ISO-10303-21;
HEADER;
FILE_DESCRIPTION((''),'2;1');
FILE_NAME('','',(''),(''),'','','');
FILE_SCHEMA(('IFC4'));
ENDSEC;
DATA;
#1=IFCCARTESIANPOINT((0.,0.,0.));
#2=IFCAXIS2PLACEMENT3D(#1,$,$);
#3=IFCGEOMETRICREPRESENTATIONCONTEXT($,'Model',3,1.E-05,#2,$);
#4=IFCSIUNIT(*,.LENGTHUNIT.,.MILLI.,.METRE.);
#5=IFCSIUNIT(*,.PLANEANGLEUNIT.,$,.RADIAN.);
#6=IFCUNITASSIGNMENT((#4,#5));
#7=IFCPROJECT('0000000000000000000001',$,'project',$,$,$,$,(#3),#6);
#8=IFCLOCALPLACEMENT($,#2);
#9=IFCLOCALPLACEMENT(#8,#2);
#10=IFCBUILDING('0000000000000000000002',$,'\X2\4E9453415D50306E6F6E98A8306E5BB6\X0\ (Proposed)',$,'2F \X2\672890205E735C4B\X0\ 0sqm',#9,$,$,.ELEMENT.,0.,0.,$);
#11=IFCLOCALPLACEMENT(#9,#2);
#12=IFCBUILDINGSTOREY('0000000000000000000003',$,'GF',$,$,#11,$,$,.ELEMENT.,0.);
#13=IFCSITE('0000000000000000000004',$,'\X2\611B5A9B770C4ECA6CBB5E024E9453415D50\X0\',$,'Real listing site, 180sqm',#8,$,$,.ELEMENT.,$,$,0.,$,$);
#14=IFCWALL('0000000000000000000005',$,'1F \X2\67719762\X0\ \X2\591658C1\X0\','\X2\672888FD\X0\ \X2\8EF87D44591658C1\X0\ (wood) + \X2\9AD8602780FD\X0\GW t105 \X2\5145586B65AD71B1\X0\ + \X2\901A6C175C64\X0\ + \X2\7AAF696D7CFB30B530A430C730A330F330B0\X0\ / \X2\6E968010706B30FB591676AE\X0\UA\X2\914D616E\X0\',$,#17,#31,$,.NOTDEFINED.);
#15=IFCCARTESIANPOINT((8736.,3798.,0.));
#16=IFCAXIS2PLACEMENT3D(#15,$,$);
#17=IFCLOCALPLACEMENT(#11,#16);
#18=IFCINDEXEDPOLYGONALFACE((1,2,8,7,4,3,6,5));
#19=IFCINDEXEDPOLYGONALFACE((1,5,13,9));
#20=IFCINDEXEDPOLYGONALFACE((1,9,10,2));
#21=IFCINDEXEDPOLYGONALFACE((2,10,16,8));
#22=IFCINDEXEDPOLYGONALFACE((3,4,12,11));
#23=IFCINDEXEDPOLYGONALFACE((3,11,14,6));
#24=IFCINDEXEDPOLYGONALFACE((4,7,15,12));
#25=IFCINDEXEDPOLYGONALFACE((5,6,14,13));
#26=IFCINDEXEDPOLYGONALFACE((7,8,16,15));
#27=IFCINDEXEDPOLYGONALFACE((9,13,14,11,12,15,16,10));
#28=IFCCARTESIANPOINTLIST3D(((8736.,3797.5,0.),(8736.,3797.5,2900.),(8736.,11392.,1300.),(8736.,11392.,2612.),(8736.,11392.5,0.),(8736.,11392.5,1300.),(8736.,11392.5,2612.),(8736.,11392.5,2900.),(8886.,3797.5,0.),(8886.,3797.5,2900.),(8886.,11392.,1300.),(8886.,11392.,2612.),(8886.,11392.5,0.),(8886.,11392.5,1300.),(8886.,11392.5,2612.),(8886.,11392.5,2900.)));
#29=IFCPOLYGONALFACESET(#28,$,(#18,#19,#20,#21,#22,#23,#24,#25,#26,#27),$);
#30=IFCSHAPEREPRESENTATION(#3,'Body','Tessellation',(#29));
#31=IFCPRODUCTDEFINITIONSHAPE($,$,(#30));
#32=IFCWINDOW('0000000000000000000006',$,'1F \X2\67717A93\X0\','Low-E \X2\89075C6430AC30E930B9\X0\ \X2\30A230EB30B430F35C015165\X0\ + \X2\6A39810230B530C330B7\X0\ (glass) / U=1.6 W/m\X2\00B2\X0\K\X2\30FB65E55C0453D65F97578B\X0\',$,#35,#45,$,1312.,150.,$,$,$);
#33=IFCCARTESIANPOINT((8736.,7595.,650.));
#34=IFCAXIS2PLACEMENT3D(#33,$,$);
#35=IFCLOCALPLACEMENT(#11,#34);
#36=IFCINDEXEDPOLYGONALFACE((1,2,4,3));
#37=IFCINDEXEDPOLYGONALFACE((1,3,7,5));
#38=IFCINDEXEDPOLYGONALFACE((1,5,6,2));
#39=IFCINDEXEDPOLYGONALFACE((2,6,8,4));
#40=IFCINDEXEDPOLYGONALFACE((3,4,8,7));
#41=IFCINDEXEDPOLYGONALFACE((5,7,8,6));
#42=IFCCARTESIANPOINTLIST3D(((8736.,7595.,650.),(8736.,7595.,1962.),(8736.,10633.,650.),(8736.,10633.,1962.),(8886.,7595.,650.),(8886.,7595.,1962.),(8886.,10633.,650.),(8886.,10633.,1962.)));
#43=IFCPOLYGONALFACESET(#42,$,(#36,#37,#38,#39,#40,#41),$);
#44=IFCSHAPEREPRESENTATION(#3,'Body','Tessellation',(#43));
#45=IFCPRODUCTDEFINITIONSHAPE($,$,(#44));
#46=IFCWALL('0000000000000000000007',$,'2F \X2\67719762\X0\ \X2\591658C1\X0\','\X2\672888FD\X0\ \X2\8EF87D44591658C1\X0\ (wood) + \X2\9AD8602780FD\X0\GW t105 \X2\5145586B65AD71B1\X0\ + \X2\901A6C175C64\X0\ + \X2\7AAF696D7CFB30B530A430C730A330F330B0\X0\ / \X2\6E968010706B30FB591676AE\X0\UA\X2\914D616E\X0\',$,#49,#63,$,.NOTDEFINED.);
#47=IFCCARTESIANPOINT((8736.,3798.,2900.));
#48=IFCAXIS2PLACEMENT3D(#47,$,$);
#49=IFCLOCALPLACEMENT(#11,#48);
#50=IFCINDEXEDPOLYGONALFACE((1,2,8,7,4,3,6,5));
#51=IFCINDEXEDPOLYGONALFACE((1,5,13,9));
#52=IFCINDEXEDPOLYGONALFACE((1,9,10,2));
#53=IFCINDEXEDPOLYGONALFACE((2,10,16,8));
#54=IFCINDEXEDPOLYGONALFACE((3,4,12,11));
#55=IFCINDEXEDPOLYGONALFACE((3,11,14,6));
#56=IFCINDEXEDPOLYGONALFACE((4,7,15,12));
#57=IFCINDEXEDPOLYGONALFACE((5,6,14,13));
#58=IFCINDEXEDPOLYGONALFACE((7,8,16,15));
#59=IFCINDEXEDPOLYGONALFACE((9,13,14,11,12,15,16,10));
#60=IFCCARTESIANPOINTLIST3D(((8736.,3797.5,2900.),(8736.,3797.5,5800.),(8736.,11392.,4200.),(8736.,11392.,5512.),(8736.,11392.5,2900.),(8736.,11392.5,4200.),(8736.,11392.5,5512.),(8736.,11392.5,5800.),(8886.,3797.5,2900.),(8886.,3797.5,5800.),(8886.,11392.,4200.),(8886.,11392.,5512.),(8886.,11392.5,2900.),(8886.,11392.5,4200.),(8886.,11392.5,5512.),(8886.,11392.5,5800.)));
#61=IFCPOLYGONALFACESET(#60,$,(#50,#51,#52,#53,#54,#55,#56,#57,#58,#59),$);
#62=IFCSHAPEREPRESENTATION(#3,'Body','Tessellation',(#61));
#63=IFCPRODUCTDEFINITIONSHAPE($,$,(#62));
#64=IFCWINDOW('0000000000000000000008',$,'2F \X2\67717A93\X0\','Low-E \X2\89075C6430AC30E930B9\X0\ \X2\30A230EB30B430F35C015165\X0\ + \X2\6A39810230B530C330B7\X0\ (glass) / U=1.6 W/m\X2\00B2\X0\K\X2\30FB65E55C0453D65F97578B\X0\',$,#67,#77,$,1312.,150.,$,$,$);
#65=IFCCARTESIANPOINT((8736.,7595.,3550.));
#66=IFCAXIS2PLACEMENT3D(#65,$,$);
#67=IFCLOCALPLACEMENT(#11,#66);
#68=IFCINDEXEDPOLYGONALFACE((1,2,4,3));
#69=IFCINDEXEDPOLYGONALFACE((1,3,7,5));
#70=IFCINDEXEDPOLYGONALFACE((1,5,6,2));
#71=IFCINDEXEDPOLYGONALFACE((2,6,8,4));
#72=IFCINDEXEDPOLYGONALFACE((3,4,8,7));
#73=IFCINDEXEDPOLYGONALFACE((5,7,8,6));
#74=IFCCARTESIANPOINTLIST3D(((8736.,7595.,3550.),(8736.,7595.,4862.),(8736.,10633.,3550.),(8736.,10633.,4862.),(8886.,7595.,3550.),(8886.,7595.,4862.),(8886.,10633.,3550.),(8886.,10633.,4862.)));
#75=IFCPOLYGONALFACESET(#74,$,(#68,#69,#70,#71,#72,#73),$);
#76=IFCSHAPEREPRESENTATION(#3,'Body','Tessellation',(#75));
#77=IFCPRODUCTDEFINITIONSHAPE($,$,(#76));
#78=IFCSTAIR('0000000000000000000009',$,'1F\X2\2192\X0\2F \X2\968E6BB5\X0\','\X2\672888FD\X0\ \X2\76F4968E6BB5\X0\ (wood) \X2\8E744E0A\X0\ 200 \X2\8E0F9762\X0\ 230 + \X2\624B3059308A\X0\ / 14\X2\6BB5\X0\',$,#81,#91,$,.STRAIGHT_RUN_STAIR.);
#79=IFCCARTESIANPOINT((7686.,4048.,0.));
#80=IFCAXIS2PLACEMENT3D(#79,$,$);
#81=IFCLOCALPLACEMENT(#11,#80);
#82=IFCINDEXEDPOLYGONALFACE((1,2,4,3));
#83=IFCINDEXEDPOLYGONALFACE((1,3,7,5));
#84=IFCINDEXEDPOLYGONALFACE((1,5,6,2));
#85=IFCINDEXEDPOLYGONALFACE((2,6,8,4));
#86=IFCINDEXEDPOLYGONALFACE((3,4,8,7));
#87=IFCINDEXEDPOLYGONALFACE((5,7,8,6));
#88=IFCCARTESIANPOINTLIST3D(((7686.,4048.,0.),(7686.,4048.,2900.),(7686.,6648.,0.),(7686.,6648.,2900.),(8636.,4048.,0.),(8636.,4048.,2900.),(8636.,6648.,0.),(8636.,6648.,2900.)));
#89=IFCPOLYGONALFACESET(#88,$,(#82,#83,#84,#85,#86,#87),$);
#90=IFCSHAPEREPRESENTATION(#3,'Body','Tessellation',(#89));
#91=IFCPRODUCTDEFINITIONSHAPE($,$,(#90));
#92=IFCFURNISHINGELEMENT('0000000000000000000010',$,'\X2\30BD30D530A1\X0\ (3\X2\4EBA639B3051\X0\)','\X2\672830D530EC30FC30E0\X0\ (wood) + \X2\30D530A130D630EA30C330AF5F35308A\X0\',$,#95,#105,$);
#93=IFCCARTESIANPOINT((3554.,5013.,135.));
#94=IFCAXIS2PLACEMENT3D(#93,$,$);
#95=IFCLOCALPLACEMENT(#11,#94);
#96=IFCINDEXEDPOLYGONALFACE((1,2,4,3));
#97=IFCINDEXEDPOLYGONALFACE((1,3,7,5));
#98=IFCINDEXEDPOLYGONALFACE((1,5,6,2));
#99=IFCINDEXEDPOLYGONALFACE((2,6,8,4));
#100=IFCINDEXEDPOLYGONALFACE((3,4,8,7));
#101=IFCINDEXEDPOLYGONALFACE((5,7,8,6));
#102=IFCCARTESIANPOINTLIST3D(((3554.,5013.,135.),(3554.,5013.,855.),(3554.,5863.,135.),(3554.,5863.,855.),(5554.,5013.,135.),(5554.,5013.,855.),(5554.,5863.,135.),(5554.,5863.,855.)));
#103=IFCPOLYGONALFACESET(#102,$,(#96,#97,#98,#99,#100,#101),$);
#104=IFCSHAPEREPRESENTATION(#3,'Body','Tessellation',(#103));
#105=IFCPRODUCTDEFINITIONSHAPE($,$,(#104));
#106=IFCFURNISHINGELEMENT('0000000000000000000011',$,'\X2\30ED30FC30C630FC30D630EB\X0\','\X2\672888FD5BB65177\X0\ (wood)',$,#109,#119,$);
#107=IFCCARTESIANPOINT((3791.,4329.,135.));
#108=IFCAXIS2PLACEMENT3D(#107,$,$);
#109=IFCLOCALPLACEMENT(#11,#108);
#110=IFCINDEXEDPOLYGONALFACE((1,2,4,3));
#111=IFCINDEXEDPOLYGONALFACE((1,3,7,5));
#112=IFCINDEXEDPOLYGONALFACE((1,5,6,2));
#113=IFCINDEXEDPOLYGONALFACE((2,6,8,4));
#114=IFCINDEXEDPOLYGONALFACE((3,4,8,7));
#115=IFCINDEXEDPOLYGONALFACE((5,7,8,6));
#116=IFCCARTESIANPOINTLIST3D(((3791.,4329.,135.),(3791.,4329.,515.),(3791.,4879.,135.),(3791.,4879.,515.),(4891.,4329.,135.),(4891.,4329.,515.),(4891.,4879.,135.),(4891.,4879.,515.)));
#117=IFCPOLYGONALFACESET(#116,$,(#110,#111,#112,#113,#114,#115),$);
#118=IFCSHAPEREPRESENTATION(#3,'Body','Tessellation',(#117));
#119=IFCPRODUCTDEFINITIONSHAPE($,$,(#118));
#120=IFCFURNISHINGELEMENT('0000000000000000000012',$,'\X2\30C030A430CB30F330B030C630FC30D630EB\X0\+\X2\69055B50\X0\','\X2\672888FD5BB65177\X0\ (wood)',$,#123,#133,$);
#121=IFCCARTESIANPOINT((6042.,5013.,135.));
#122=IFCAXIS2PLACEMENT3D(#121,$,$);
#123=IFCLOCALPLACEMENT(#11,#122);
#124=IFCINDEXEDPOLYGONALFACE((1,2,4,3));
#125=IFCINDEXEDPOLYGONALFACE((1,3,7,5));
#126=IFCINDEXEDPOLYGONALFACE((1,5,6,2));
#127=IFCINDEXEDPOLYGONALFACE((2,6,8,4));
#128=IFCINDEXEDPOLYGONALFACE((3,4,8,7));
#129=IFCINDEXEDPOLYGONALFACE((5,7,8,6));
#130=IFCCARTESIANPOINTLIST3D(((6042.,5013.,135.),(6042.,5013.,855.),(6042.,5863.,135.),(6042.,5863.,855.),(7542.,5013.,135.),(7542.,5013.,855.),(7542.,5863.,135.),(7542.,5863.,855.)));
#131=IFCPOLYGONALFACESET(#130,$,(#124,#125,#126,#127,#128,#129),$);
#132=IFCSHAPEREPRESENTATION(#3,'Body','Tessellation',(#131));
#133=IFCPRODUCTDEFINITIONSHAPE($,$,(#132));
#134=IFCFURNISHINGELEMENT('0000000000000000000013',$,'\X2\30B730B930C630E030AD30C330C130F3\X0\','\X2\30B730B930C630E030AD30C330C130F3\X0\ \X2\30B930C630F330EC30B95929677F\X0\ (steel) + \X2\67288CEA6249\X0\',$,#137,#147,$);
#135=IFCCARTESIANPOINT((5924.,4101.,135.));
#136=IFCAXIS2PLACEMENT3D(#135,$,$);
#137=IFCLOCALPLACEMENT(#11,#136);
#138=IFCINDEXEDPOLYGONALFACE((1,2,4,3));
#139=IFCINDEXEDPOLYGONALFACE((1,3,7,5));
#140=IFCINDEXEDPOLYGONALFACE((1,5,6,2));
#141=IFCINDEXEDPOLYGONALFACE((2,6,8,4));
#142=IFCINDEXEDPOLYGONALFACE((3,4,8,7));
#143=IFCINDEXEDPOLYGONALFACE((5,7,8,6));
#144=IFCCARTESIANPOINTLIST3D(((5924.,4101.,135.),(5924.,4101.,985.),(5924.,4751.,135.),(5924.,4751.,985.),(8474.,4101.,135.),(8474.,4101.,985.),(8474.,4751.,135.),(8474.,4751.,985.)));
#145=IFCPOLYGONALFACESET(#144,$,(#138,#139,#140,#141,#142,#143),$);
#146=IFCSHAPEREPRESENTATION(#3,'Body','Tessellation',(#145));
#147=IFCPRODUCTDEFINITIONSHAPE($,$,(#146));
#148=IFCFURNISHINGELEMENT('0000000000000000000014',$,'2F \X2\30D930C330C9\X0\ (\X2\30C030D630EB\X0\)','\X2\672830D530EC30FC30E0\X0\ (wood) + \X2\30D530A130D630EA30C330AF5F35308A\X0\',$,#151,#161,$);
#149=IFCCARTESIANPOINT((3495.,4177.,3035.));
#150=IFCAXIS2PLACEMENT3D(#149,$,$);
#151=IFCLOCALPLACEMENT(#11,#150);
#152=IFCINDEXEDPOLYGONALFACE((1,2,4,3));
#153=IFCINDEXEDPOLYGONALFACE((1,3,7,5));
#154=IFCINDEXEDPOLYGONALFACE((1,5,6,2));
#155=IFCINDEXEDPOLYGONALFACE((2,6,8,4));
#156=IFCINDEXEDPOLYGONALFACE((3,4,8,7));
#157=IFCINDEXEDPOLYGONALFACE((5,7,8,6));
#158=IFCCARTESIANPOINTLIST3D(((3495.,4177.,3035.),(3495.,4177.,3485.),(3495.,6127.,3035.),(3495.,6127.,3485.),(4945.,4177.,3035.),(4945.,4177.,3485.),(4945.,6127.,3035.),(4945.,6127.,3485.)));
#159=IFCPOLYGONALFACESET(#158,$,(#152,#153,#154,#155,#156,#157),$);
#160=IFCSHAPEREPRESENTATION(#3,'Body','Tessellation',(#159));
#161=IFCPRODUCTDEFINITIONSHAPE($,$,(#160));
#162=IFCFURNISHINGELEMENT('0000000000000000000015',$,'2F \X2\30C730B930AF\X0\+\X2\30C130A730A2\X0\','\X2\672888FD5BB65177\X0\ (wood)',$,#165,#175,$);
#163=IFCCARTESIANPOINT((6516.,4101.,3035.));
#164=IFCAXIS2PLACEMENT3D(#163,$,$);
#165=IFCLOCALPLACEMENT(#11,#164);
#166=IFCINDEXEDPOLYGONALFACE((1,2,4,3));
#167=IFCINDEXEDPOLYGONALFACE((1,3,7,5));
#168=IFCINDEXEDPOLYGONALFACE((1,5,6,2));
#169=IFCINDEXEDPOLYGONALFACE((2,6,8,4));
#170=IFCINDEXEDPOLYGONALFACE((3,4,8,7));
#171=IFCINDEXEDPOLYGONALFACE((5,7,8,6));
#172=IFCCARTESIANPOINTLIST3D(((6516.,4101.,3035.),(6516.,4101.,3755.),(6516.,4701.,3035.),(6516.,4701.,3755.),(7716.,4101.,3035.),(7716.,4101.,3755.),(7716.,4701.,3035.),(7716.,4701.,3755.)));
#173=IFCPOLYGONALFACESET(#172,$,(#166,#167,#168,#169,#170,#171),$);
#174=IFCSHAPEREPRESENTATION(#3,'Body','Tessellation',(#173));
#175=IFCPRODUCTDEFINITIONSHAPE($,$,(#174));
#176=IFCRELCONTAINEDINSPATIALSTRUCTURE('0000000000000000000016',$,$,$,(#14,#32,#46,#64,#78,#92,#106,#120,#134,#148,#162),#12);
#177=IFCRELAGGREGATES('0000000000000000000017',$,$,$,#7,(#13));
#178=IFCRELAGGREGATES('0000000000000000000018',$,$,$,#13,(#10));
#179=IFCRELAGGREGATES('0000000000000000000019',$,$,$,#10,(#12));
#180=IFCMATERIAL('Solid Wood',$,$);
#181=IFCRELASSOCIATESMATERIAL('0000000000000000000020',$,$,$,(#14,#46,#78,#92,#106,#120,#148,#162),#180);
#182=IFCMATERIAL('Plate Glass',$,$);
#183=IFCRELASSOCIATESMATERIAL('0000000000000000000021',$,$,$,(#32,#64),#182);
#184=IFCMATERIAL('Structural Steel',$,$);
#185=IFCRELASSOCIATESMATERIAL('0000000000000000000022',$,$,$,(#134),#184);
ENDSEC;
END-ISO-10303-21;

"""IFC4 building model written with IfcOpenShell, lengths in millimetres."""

from ifc_helpers import new_model, si_unit, frame, frame_2d, origin, place, context, project, spatial, rectangle, extrude, material, element, fill, save


model = new_model("IFC4")

# Units and contexts
model_context = context("Model", 3, precision=1e-05, world=origin())
ifc_project = project(units=[si_unit("LENGTHUNIT", "METRE", prefix="MILLI"), si_unit("PLANEANGLEUNIT", "RADIAN")], contexts=[model_context])

# Site, building, storey
site_placement = place(None, origin())
site = spatial("IfcSite", under=ifc_project, at=site_placement, Name="愛媛県今治市五十嵐", ObjectType="Real listing site, 180sqm", CompositionType="ELEMENT", RefElevation=0.0)
building_placement = place(site_placement, origin())
building = spatial("IfcBuilding", under=site, at=building_placement, Name="五十嵐の潮風の家 (Proposed)", ObjectType="2F 木造平屋 0sqm", CompositionType="ELEMENT", ElevationOfRefHeight=0.0, ElevationOfTerrain=0.0)
storey_placement = place(building_placement, origin())
storey = spatial("IfcBuildingStorey", under=building, at=storey_placement, Name="GF", CompositionType="ELEMENT", Elevation=0.0)

# Wall, opening, window
ifc_material_1 = material(Name="Solid Wood")
wall_1_placement = place(storey_placement, frame((8736.0, 3798.0, 0.0)))
wall_1 = element("IfcWall", 1, at=wall_1_placement, inside=storey, material=ifc_material_1, Name="1F 東面 外壁", Description="木製 軸組外壁 (wood) + 高性能GW t105 充填断熱 + 通気層 + 窯業系サイディング / 準耐火・外皮UA配慮", PredefinedType="NOTDEFINED", context=model_context, shape_type="SweptSolid", body=[
    extrude(rectangle(XDim=150.0, YDim=7595.0, at=frame_2d((75.0, 3797.0))), frame((8736.0, 3798.0, 0.0)), (0.0, 0.0, 1.0), 2900.0),
])
opening_1_placement = place(storey_placement, frame((8736.0, 7595.0, 650.0)))
opening_1 = element("IfcOpeningElement", 2, at=opening_1_placement, cuts=wall_1, PredefinedType="NOTDEFINED", context=model_context, shape_type="SweptSolid", body=[
    extrude(rectangle(XDim=150.0, YDim=3038.0, at=frame_2d((75.0, 1519.0))), frame((8736.0, 7595.0, 650.0)), (0.0, 0.0, 1.0), 1312.0),
])
ifc_material_2 = material(Name="Plate Glass")
window_1_placement = place(storey_placement, frame((8736.0, 7595.0, 650.0)))
window_1 = element("IfcWindow", 3, at=window_1_placement, inside=storey, material=ifc_material_2, Name="1F 東窓", Description="Low-E 複層ガラス アルゴン封入 + 樹脂サッシ (glass) / U=1.6 W/m²K・日射取得型", OverallHeight=1312.0, OverallWidth=150.0, context=model_context, shape_type="SweptSolid", body=[
    extrude(rectangle(XDim=150.0, YDim=3038.0, at=frame_2d((75.0, 1519.0))), frame((8736.0, 7595.0, 650.0)), (0.0, 0.0, 1.0), 1312.0),
])
fill(opening_1, window_1)

# Wall, opening, window
wall_2_placement = place(storey_placement, frame((8736.0, 3798.0, 2900.0)))
wall_2 = element("IfcWall", 4, at=wall_2_placement, inside=storey, material=ifc_material_1, Name="2F 東面 外壁", Description="木製 軸組外壁 (wood) + 高性能GW t105 充填断熱 + 通気層 + 窯業系サイディング / 準耐火・外皮UA配慮", PredefinedType="NOTDEFINED", context=model_context, shape_type="SweptSolid", body=[
    extrude(rectangle(XDim=150.0, YDim=7595.0, at=frame_2d((75.0, 3797.0))), frame((8736.0, 3798.0, 2900.0)), (0.0, 0.0, 1.0), 2900.0),
])
opening_2_placement = place(storey_placement, frame((8736.0, 7595.0, 3550.0)))
opening_2 = element("IfcOpeningElement", 5, at=opening_2_placement, cuts=wall_2, PredefinedType="NOTDEFINED", context=model_context, shape_type="SweptSolid", body=[
    extrude(rectangle(XDim=150.0, YDim=3038.0, at=frame_2d((75.0, 1519.0))), frame((8736.0, 7595.0, 3550.0)), (0.0, 0.0, 1.0), 1312.0),
])
window_2_placement = place(storey_placement, frame((8736.0, 7595.0, 3550.0)))
window_2 = element("IfcWindow", 6, at=window_2_placement, inside=storey, material=ifc_material_2, Name="2F 東窓", Description="Low-E 複層ガラス アルゴン封入 + 樹脂サッシ (glass) / U=1.6 W/m²K・日射取得型", OverallHeight=1312.0, OverallWidth=150.0, context=model_context, shape_type="SweptSolid", body=[
    extrude(rectangle(XDim=150.0, YDim=3038.0, at=frame_2d((75.0, 1519.0))), frame((8736.0, 7595.0, 3550.0)), (0.0, 0.0, 1.0), 1312.0),
])
fill(opening_2, window_2)

# Stair
stair_placement = place(storey_placement, frame((7686.0, 4048.0, 0.0)))
element("IfcStair", 7, at=stair_placement, inside=storey, material=ifc_material_1, Name="1F→2F 階段", Description="木製 直階段 (wood) 蹴上 200 踏面 230 + 手すり / 14段", PredefinedType="STRAIGHT_RUN_STAIR", context=model_context, shape_type="SweptSolid", body=[
    extrude(rectangle(XDim=950.0, YDim=2600.0, at=frame_2d((475.0, 1300.0))), frame((7686.0, 4048.0, 0.0)), (0.0, 0.0, 1.0), 2900.0),
])

# Furnishing elements
furnishing_1_placement = place(storey_placement, frame((3554.0, 5013.0, 135.0)))
element("IfcFurnishingElement", 8, at=furnishing_1_placement, inside=storey, material=ifc_material_1, Name="ソファ (3人掛け)", Description="木フレーム (wood) + ファブリック張り", context=model_context, shape_type="SweptSolid", body=[
    extrude(rectangle(XDim=2000.0, YDim=850.0, at=frame_2d((1000.0, 425.0))), frame((3554.0, 5013.0, 135.0)), (0.0, 0.0, 1.0), 720.0),
])
furnishing_2_placement = place(storey_placement, frame((3791.0, 4329.0, 135.0)))
element("IfcFurnishingElement", 9, at=furnishing_2_placement, inside=storey, material=ifc_material_1, Name="ローテーブル", Description="木製家具 (wood)", context=model_context, shape_type="SweptSolid", body=[
    extrude(rectangle(XDim=1100.0, YDim=550.0, at=frame_2d((550.0, 275.0))), frame((3791.0, 4329.0, 135.0)), (0.0, 0.0, 1.0), 380.0),
])
furnishing_3_placement = place(storey_placement, frame((6042.0, 5013.0, 135.0)))
element("IfcFurnishingElement", 10, at=furnishing_3_placement, inside=storey, material=ifc_material_1, Name="ダイニングテーブル+椅子", Description="木製家具 (wood)", context=model_context, shape_type="SweptSolid", body=[
    extrude(rectangle(XDim=1500.0, YDim=850.0, at=frame_2d((750.0, 425.0))), frame((6042.0, 5013.0, 135.0)), (0.0, 0.0, 1.0), 720.0),
])
ifc_material_3 = material(Name="Structural Steel")
furnishing_4_placement = place(storey_placement, frame((5924.0, 4101.0, 135.0)))
element("IfcFurnishingElement", 11, at=furnishing_4_placement, inside=storey, material=ifc_material_3, Name="システムキッチン", Description="システムキッチン ステンレス天板 (steel) + 木質扉", context=model_context, shape_type="SweptSolid", body=[
    extrude(rectangle(XDim=2550.0, YDim=650.0, at=frame_2d((1275.0, 325.0))), frame((5924.0, 4101.0, 135.0)), (0.0, 0.0, 1.0), 850.0),
])
furnishing_5_placement = place(storey_placement, frame((3495.0, 4177.0, 3035.0)))
element("IfcFurnishingElement", 12, at=furnishing_5_placement, inside=storey, material=ifc_material_1, Name="2F ベッド (ダブル)", Description="木フレーム (wood) + ファブリック張り", context=model_context, shape_type="SweptSolid", body=[
    extrude(rectangle(XDim=1450.0, YDim=1950.0, at=frame_2d((725.0, 975.0))), frame((3495.0, 4177.0, 3035.0)), (0.0, 0.0, 1.0), 450.0),
])
furnishing_6_placement = place(storey_placement, frame((6516.0, 4101.0, 3035.0)))
element("IfcFurnishingElement", 13, at=furnishing_6_placement, inside=storey, material=ifc_material_1, Name="2F デスク+チェア", Description="木製家具 (wood)", context=model_context, shape_type="SweptSolid", body=[
    extrude(rectangle(XDim=1200.0, YDim=600.0, at=frame_2d((600.0, 300.0))), frame((6516.0, 4101.0, 3035.0)), (0.0, 0.0, 1.0), 720.0),
])

save(model, "model.ifc")
